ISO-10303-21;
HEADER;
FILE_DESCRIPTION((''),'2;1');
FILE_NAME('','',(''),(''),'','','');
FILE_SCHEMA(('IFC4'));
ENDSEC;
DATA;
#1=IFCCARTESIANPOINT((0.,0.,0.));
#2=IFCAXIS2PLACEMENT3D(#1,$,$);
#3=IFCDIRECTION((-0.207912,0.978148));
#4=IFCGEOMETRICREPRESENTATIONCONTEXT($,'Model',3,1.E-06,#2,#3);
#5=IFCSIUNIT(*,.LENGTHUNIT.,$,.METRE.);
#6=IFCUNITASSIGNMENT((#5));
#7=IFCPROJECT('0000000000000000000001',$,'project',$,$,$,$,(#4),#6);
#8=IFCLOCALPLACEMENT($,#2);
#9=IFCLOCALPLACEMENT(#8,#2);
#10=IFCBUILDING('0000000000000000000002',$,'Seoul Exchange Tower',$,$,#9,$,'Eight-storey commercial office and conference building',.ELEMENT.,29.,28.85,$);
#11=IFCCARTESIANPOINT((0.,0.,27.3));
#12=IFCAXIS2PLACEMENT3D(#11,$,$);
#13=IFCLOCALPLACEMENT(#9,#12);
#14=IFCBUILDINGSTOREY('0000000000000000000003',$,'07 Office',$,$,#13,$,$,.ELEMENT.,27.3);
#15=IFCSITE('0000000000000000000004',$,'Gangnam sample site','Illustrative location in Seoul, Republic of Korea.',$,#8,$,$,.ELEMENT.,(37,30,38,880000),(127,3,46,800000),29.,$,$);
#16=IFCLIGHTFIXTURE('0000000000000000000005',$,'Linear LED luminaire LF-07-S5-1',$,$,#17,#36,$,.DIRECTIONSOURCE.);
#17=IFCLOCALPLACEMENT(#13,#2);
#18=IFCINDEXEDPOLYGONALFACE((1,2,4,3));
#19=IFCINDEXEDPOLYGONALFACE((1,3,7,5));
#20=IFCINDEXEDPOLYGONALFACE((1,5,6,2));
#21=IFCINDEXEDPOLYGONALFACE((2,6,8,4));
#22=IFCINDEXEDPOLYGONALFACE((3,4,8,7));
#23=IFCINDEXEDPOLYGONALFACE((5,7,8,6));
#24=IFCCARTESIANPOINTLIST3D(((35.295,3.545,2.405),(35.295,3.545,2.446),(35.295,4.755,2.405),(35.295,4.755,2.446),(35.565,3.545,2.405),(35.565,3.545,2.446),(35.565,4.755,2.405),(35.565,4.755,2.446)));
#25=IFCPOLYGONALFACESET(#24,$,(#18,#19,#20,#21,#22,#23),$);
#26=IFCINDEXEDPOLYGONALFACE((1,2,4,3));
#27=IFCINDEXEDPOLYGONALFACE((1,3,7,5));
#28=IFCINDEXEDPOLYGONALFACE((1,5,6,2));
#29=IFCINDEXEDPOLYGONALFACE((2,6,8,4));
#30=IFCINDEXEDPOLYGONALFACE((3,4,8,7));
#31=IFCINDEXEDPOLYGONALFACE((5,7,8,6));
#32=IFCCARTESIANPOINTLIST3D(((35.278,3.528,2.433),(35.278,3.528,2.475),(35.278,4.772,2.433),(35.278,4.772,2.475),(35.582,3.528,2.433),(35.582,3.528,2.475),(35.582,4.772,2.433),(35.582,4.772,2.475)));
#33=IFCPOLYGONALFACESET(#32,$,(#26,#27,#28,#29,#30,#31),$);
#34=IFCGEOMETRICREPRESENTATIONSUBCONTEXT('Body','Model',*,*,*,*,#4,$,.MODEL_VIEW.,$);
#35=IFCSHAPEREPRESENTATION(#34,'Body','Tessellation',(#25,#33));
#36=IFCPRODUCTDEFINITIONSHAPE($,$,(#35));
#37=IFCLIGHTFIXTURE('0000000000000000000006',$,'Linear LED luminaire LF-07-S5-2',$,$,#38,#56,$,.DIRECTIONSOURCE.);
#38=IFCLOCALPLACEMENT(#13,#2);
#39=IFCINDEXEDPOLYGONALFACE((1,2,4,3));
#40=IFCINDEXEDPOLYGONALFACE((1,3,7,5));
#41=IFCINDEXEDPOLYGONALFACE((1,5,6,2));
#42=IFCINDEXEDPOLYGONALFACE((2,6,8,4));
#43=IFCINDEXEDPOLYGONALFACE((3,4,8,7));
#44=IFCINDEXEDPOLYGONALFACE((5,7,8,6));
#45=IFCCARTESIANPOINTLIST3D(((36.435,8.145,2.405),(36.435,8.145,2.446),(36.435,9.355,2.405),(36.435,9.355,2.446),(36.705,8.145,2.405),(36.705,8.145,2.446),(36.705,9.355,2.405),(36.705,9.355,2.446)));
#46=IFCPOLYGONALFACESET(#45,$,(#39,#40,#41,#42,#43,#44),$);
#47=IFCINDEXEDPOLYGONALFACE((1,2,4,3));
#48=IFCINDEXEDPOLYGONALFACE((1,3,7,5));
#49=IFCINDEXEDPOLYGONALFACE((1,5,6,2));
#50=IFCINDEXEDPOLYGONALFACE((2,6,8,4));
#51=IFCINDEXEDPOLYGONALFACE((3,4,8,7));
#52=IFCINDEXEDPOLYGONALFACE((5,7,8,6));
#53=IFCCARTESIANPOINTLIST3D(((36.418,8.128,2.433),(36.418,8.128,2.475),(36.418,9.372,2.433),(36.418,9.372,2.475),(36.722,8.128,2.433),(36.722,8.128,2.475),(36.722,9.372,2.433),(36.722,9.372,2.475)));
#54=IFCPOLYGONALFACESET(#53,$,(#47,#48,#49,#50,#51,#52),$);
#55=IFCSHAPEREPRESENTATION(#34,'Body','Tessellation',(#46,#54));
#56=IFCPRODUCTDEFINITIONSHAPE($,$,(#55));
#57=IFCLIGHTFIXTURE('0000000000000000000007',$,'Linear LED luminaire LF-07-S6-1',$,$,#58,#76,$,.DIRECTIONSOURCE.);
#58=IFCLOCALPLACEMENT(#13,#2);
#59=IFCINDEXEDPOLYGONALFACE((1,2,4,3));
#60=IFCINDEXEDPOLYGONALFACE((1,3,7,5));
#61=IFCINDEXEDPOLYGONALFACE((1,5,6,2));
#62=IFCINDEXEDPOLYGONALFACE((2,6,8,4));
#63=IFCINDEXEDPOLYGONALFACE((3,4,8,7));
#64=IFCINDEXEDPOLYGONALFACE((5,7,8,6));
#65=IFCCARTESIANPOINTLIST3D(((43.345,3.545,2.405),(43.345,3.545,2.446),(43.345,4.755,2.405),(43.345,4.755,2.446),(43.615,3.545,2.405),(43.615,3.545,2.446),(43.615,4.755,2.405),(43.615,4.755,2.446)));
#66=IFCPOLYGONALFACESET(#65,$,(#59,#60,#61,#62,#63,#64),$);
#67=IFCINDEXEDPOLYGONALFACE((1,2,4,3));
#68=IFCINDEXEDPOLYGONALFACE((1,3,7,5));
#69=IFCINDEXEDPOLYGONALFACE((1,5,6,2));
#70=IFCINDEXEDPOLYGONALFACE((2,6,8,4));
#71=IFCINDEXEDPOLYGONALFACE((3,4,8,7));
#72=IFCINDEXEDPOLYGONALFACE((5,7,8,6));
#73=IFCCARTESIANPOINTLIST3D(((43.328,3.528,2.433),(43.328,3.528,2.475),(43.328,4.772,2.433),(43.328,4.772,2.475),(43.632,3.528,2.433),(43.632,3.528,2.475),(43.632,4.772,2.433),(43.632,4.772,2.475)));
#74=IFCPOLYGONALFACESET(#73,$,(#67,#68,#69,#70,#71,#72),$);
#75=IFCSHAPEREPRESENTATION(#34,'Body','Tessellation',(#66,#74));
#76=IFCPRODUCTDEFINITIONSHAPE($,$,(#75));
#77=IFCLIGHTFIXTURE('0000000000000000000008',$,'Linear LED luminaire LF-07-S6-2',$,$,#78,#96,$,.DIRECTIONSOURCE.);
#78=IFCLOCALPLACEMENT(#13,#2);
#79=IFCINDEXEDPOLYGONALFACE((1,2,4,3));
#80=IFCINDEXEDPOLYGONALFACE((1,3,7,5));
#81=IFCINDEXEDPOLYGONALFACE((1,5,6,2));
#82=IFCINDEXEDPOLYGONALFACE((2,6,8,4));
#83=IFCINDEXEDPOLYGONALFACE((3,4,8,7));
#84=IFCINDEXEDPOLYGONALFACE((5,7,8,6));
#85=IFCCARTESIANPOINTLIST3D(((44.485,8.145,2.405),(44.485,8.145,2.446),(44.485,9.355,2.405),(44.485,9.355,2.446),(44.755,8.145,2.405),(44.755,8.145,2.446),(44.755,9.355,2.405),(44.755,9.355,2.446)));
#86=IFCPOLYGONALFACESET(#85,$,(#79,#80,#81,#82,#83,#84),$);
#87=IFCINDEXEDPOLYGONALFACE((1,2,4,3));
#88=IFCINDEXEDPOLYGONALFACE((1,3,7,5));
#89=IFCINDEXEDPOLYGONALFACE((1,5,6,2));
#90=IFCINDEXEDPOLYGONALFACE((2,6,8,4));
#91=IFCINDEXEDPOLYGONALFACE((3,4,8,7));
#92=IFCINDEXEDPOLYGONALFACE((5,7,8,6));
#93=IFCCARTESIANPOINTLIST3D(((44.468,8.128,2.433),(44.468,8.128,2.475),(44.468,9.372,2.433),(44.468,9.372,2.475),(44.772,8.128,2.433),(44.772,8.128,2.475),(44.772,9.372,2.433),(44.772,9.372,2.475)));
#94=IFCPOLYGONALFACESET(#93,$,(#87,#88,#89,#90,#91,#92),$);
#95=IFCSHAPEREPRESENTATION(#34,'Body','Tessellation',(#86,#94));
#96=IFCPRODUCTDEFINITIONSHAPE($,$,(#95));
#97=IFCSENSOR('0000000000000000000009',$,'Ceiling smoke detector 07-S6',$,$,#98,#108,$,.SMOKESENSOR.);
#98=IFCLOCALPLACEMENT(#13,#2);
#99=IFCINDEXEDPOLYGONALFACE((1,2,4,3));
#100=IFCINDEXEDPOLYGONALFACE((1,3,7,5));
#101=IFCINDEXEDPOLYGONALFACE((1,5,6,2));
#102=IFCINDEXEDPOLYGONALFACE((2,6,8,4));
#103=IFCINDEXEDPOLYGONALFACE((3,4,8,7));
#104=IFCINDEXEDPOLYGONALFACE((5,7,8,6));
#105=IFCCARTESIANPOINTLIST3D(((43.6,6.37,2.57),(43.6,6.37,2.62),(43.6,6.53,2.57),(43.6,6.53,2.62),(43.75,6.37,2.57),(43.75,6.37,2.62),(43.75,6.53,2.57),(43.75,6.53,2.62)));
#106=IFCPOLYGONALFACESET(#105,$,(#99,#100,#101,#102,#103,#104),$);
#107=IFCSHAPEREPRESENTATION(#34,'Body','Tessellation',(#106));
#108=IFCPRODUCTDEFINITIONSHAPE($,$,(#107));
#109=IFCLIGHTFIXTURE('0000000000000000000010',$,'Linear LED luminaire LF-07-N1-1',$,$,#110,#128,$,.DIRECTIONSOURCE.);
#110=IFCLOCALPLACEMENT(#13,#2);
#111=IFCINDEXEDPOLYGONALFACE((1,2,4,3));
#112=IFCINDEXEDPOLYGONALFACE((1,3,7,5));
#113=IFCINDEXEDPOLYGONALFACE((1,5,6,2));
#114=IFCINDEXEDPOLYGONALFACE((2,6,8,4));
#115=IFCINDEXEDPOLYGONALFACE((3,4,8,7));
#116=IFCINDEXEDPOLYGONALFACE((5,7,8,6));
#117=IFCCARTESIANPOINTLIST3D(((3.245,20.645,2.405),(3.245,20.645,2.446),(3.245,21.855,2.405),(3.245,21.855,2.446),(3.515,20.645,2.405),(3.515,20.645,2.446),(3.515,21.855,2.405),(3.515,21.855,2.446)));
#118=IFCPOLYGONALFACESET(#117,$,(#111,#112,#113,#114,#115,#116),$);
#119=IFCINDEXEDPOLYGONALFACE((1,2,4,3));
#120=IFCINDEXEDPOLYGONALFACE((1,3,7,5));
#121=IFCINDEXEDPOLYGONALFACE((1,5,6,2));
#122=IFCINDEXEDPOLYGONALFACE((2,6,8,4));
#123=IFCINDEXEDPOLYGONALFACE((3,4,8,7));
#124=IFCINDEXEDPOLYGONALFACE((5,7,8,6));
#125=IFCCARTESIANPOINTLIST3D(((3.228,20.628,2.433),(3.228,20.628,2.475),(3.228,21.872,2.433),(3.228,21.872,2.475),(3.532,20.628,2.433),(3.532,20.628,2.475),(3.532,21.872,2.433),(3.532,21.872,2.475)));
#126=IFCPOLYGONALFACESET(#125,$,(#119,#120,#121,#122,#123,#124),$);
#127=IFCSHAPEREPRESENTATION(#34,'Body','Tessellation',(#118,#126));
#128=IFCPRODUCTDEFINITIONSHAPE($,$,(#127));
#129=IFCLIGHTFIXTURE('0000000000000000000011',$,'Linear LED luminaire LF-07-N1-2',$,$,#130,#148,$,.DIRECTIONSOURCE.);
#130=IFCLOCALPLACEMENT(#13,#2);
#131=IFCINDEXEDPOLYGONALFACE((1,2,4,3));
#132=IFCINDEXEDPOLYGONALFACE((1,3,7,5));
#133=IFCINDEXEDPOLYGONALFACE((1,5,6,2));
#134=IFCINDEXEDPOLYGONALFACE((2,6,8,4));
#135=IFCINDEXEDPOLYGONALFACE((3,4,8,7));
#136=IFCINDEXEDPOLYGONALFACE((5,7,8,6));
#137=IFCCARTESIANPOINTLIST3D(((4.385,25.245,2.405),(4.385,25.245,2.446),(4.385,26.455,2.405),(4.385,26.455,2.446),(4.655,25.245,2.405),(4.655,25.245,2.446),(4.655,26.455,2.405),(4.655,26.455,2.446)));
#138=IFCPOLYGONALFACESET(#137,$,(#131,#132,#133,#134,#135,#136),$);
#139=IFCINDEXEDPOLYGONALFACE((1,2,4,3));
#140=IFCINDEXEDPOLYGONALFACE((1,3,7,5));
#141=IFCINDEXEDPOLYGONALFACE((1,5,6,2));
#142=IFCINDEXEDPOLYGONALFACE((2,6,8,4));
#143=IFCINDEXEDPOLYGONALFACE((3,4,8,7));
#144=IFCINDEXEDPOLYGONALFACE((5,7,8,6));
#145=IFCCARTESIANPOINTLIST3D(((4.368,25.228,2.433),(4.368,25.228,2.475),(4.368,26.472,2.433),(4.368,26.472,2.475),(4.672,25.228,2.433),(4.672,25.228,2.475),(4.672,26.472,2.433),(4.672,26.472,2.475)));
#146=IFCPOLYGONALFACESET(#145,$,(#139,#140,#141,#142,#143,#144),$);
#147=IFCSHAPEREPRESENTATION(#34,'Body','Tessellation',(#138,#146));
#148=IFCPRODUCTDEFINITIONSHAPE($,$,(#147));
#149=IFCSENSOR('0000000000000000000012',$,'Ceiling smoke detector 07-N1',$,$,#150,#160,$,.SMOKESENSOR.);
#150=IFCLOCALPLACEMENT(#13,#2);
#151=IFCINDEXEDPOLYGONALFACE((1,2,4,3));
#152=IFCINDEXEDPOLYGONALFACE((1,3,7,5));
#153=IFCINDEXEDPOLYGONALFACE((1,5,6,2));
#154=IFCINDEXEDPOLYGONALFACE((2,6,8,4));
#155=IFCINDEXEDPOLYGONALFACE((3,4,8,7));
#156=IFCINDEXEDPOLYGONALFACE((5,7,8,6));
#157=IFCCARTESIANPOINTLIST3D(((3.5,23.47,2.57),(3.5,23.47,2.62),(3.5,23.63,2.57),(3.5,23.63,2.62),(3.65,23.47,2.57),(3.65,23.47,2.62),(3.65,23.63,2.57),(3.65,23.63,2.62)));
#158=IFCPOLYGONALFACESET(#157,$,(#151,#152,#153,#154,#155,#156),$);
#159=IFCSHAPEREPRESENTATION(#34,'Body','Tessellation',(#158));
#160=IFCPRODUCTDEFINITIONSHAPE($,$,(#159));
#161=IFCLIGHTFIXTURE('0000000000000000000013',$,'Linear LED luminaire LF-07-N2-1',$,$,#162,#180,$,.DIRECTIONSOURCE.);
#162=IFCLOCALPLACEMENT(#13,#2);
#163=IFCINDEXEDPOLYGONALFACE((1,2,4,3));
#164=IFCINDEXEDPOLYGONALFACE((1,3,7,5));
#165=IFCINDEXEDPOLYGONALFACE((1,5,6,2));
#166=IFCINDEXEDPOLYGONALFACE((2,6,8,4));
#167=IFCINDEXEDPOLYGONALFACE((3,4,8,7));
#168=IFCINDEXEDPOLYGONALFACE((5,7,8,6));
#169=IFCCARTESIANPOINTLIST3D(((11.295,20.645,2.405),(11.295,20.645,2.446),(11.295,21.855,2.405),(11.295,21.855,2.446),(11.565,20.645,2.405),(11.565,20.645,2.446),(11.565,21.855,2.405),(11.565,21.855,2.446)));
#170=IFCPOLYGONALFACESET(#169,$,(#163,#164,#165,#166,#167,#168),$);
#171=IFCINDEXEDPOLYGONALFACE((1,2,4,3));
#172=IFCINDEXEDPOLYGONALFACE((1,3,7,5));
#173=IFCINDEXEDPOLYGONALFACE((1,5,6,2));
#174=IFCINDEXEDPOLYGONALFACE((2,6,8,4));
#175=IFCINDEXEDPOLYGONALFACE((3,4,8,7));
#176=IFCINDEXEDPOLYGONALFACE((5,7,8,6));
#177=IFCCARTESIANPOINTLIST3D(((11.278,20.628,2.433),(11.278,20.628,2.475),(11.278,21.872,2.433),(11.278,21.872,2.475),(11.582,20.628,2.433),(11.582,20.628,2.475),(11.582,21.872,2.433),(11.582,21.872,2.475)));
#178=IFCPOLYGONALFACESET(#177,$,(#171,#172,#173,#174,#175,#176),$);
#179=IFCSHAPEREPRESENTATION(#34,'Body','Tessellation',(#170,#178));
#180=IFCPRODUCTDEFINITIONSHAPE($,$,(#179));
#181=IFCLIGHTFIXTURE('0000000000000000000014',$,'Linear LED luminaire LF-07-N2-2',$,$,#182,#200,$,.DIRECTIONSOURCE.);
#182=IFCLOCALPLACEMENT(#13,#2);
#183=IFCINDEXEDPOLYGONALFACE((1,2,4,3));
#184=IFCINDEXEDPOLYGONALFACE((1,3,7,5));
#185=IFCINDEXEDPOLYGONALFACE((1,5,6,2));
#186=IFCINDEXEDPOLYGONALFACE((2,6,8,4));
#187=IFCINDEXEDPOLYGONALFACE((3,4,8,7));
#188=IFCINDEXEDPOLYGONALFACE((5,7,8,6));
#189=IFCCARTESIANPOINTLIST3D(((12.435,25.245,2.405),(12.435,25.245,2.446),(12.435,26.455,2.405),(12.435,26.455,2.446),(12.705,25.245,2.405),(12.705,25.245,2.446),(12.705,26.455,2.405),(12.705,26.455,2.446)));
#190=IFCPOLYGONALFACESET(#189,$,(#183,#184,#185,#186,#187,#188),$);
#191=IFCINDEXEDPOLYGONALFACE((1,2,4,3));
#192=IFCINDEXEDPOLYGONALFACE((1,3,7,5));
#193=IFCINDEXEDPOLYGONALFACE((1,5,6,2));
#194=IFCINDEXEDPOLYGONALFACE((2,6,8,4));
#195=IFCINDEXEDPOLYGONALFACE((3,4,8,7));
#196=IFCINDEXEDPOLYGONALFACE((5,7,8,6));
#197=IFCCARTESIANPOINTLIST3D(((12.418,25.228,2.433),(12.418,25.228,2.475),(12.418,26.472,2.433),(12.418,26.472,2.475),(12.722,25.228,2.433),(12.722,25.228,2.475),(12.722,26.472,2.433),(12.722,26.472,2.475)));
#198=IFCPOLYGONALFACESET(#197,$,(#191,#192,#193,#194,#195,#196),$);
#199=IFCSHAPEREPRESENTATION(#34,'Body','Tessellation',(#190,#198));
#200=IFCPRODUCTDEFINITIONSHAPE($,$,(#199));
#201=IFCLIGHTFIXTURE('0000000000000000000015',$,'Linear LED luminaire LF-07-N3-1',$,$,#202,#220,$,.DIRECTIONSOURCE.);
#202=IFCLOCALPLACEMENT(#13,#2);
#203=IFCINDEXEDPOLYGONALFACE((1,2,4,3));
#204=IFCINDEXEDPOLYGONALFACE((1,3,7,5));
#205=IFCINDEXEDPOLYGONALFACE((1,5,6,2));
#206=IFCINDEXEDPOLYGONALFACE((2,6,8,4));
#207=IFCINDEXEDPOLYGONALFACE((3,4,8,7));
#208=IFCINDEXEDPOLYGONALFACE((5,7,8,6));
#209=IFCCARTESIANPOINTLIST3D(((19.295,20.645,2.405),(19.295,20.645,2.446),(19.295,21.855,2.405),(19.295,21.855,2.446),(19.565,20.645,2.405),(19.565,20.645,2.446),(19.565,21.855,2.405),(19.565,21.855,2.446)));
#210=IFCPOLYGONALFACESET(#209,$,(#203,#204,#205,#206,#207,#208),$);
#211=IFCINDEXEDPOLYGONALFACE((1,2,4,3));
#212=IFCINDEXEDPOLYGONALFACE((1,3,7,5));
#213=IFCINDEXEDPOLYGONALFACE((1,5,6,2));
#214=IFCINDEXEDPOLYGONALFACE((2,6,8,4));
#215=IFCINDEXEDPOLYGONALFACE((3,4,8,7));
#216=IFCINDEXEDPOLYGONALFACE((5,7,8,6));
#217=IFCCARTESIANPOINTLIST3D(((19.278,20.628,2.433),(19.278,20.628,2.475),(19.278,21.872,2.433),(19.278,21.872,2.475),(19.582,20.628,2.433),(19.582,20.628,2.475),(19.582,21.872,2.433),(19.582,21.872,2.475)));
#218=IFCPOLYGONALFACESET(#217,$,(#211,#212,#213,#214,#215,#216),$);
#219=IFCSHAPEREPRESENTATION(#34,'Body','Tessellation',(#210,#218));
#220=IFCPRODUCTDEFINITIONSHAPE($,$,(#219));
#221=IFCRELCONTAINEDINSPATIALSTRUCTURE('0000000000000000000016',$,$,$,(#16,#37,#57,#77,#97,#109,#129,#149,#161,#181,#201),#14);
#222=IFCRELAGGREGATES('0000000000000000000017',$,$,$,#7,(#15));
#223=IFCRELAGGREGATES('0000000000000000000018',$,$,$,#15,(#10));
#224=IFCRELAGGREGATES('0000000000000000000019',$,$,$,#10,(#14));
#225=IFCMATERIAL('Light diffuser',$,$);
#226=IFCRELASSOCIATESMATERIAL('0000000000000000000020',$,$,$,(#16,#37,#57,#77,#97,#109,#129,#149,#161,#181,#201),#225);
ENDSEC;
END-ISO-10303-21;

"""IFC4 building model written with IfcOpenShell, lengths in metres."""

from ifc_helpers import new_model, si_unit, direction, frame, frame_2d, origin, place, context, subcontext, project, spatial, rectangle, extrude, material, element, save


model = new_model("IFC4")

# Units and contexts
model_context = context("Model", 3, precision=1e-06, world=origin(), true_north=direction((-0.207912, 0.978148)))
body_context = subcontext(model_context, "Body", "Model", "MODEL_VIEW")
ifc_project = project(units=[si_unit("LENGTHUNIT", "METRE")], contexts=[model_context])

# Site, building, storey
site_placement = place(None, origin())
site = spatial("IfcSite", under=ifc_project, at=site_placement, Name="Gangnam sample site", Description="Illustrative location in Seoul, Republic of Korea.", CompositionType="ELEMENT", RefLatitude=(37, 30, 38, 880000), RefLongitude=(127, 3, 46, 800000), RefElevation=29.0)
building_placement = place(site_placement, origin())
building = spatial("IfcBuilding", under=site, at=building_placement, Name="Seoul Exchange Tower", LongName="Eight-storey commercial office and conference building", CompositionType="ELEMENT", ElevationOfRefHeight=29.0, ElevationOfTerrain=28.85)
storey_placement = place(building_placement, frame((0.0, 0.0, 27.3)))
storey = spatial("IfcBuildingStorey", under=building, at=storey_placement, Name="07 Office", CompositionType="ELEMENT", Elevation=27.3)

# Shared definitions
placement = place(storey_placement, origin())

# Shared definitions
ifc_material_1 = material(Name="Light diffuser")

# Light fixtures
element("IfcLightFixture", 1, at=placement, inside=storey, material=ifc_material_1, Name="Linear LED luminaire LF-07-S5-1", PredefinedType="DIRECTIONSOURCE", context=body_context, shape_type="SweptSolid", body=[
    extrude(rectangle(XDim=0.27, YDim=1.21, at=frame_2d((0.135, 0.605))), frame((35.295, 3.545, 2.405)), (0.0, 0.0, 1.0), 0.041),
    extrude(rectangle(XDim=0.304, YDim=1.244, at=frame_2d((0.152, 0.622))), frame((35.278, 3.528, 2.433)), (0.0, 0.0, 1.0), 0.042),
])
element("IfcLightFixture", 2, at=placement, inside=storey, material=ifc_material_1, Name="Linear LED luminaire LF-07-S5-2", PredefinedType="DIRECTIONSOURCE", context=body_context, shape_type="SweptSolid", body=[
    extrude(rectangle(XDim=0.27, YDim=1.21, at=frame_2d((0.135, 0.605))), frame((36.435, 8.145, 2.405)), (0.0, 0.0, 1.0), 0.041),
    extrude(rectangle(XDim=0.304, YDim=1.244, at=frame_2d((0.152, 0.622))), frame((36.418, 8.128, 2.433)), (0.0, 0.0, 1.0), 0.042),
])
element("IfcLightFixture", 3, at=placement, inside=storey, material=ifc_material_1, Name="Linear LED luminaire LF-07-S6-1", PredefinedType="DIRECTIONSOURCE", context=body_context, shape_type="SweptSolid", body=[
    extrude(rectangle(XDim=0.27, YDim=1.21, at=frame_2d((0.135, 0.605))), frame((43.345, 3.545, 2.405)), (0.0, 0.0, 1.0), 0.041),
    extrude(rectangle(XDim=0.304, YDim=1.244, at=frame_2d((0.152, 0.622))), frame((43.328, 3.528, 2.433)), (0.0, 0.0, 1.0), 0.042),
])
element("IfcLightFixture", 4, at=placement, inside=storey, material=ifc_material_1, Name="Linear LED luminaire LF-07-S6-2", PredefinedType="DIRECTIONSOURCE", context=body_context, shape_type="SweptSolid", body=[
    extrude(rectangle(XDim=0.27, YDim=1.21, at=frame_2d((0.135, 0.605))), frame((44.485, 8.145, 2.405)), (0.0, 0.0, 1.0), 0.041),
    extrude(rectangle(XDim=0.304, YDim=1.244, at=frame_2d((0.152, 0.622))), frame((44.468, 8.128, 2.433)), (0.0, 0.0, 1.0), 0.042),
])

# Sensor
element("IfcSensor", 5, at=placement, inside=storey, material=ifc_material_1, Name="Ceiling smoke detector 07-S6", PredefinedType="SMOKESENSOR", context=body_context, shape_type="SweptSolid", body=[
    extrude(rectangle(XDim=0.15, YDim=0.16, at=frame_2d((0.075, 0.08))), frame((43.6, 6.37, 2.57)), (0.0, 0.0, 1.0), 0.05),
])

# Light fixtures
element("IfcLightFixture", 6, at=placement, inside=storey, material=ifc_material_1, Name="Linear LED luminaire LF-07-N1-1", PredefinedType="DIRECTIONSOURCE", context=body_context, shape_type="SweptSolid", body=[
    extrude(rectangle(XDim=0.27, YDim=1.21, at=frame_2d((0.135, 0.605))), frame((3.245, 20.645, 2.405)), (0.0, 0.0, 1.0), 0.041),
    extrude(rectangle(XDim=0.304, YDim=1.244, at=frame_2d((0.152, 0.622))), frame((3.228, 20.628, 2.433)), (0.0, 0.0, 1.0), 0.042),
])
element("IfcLightFixture", 7, at=placement, inside=storey, material=ifc_material_1, Name="Linear LED luminaire LF-07-N1-2", PredefinedType="DIRECTIONSOURCE", context=body_context, shape_type="SweptSolid", body=[
    extrude(rectangle(XDim=0.27, YDim=1.21, at=frame_2d((0.135, 0.605))), frame((4.385, 25.245, 2.405)), (0.0, 0.0, 1.0), 0.041),
    extrude(rectangle(XDim=0.304, YDim=1.244, at=frame_2d((0.152, 0.622))), frame((4.368, 25.228, 2.433)), (0.0, 0.0, 1.0), 0.042),
])

# Sensor
element("IfcSensor", 8, at=placement, inside=storey, material=ifc_material_1, Name="Ceiling smoke detector 07-N1", PredefinedType="SMOKESENSOR", context=body_context, shape_type="SweptSolid", body=[
    extrude(rectangle(XDim=0.15, YDim=0.16, at=frame_2d((0.075, 0.08))), frame((3.5, 23.47, 2.57)), (0.0, 0.0, 1.0), 0.05),
])

# Light fixtures
element("IfcLightFixture", 9, at=placement, inside=storey, material=ifc_material_1, Name="Linear LED luminaire LF-07-N2-1", PredefinedType="DIRECTIONSOURCE", context=body_context, shape_type="SweptSolid", body=[
    extrude(rectangle(XDim=0.27, YDim=1.21, at=frame_2d((0.135, 0.605))), frame((11.295, 20.645, 2.405)), (0.0, 0.0, 1.0), 0.041),
    extrude(rectangle(XDim=0.304, YDim=1.244, at=frame_2d((0.152, 0.622))), frame((11.278, 20.628, 2.433)), (0.0, 0.0, 1.0), 0.042),
])
element("IfcLightFixture", 10, at=placement, inside=storey, material=ifc_material_1, Name="Linear LED luminaire LF-07-N2-2", PredefinedType="DIRECTIONSOURCE", context=body_context, shape_type="SweptSolid", body=[
    extrude(rectangle(XDim=0.27, YDim=1.21, at=frame_2d((0.135, 0.605))), frame((12.435, 25.245, 2.405)), (0.0, 0.0, 1.0), 0.041),
    extrude(rectangle(XDim=0.304, YDim=1.244, at=frame_2d((0.152, 0.622))), frame((12.418, 25.228, 2.433)), (0.0, 0.0, 1.0), 0.042),
])
element("IfcLightFixture", 11, at=placement, inside=storey, material=ifc_material_1, Name="Linear LED luminaire LF-07-N3-1", PredefinedType="DIRECTIONSOURCE", context=body_context, shape_type="SweptSolid", body=[
    extrude(rectangle(XDim=0.27, YDim=1.21, at=frame_2d((0.135, 0.605))), frame((19.295, 20.645, 2.405)), (0.0, 0.0, 1.0), 0.041),
    extrude(rectangle(XDim=0.304, YDim=1.244, at=frame_2d((0.152, 0.622))), frame((19.278, 20.628, 2.433)), (0.0, 0.0, 1.0), 0.042),
])

save(model, "model.ifc")
